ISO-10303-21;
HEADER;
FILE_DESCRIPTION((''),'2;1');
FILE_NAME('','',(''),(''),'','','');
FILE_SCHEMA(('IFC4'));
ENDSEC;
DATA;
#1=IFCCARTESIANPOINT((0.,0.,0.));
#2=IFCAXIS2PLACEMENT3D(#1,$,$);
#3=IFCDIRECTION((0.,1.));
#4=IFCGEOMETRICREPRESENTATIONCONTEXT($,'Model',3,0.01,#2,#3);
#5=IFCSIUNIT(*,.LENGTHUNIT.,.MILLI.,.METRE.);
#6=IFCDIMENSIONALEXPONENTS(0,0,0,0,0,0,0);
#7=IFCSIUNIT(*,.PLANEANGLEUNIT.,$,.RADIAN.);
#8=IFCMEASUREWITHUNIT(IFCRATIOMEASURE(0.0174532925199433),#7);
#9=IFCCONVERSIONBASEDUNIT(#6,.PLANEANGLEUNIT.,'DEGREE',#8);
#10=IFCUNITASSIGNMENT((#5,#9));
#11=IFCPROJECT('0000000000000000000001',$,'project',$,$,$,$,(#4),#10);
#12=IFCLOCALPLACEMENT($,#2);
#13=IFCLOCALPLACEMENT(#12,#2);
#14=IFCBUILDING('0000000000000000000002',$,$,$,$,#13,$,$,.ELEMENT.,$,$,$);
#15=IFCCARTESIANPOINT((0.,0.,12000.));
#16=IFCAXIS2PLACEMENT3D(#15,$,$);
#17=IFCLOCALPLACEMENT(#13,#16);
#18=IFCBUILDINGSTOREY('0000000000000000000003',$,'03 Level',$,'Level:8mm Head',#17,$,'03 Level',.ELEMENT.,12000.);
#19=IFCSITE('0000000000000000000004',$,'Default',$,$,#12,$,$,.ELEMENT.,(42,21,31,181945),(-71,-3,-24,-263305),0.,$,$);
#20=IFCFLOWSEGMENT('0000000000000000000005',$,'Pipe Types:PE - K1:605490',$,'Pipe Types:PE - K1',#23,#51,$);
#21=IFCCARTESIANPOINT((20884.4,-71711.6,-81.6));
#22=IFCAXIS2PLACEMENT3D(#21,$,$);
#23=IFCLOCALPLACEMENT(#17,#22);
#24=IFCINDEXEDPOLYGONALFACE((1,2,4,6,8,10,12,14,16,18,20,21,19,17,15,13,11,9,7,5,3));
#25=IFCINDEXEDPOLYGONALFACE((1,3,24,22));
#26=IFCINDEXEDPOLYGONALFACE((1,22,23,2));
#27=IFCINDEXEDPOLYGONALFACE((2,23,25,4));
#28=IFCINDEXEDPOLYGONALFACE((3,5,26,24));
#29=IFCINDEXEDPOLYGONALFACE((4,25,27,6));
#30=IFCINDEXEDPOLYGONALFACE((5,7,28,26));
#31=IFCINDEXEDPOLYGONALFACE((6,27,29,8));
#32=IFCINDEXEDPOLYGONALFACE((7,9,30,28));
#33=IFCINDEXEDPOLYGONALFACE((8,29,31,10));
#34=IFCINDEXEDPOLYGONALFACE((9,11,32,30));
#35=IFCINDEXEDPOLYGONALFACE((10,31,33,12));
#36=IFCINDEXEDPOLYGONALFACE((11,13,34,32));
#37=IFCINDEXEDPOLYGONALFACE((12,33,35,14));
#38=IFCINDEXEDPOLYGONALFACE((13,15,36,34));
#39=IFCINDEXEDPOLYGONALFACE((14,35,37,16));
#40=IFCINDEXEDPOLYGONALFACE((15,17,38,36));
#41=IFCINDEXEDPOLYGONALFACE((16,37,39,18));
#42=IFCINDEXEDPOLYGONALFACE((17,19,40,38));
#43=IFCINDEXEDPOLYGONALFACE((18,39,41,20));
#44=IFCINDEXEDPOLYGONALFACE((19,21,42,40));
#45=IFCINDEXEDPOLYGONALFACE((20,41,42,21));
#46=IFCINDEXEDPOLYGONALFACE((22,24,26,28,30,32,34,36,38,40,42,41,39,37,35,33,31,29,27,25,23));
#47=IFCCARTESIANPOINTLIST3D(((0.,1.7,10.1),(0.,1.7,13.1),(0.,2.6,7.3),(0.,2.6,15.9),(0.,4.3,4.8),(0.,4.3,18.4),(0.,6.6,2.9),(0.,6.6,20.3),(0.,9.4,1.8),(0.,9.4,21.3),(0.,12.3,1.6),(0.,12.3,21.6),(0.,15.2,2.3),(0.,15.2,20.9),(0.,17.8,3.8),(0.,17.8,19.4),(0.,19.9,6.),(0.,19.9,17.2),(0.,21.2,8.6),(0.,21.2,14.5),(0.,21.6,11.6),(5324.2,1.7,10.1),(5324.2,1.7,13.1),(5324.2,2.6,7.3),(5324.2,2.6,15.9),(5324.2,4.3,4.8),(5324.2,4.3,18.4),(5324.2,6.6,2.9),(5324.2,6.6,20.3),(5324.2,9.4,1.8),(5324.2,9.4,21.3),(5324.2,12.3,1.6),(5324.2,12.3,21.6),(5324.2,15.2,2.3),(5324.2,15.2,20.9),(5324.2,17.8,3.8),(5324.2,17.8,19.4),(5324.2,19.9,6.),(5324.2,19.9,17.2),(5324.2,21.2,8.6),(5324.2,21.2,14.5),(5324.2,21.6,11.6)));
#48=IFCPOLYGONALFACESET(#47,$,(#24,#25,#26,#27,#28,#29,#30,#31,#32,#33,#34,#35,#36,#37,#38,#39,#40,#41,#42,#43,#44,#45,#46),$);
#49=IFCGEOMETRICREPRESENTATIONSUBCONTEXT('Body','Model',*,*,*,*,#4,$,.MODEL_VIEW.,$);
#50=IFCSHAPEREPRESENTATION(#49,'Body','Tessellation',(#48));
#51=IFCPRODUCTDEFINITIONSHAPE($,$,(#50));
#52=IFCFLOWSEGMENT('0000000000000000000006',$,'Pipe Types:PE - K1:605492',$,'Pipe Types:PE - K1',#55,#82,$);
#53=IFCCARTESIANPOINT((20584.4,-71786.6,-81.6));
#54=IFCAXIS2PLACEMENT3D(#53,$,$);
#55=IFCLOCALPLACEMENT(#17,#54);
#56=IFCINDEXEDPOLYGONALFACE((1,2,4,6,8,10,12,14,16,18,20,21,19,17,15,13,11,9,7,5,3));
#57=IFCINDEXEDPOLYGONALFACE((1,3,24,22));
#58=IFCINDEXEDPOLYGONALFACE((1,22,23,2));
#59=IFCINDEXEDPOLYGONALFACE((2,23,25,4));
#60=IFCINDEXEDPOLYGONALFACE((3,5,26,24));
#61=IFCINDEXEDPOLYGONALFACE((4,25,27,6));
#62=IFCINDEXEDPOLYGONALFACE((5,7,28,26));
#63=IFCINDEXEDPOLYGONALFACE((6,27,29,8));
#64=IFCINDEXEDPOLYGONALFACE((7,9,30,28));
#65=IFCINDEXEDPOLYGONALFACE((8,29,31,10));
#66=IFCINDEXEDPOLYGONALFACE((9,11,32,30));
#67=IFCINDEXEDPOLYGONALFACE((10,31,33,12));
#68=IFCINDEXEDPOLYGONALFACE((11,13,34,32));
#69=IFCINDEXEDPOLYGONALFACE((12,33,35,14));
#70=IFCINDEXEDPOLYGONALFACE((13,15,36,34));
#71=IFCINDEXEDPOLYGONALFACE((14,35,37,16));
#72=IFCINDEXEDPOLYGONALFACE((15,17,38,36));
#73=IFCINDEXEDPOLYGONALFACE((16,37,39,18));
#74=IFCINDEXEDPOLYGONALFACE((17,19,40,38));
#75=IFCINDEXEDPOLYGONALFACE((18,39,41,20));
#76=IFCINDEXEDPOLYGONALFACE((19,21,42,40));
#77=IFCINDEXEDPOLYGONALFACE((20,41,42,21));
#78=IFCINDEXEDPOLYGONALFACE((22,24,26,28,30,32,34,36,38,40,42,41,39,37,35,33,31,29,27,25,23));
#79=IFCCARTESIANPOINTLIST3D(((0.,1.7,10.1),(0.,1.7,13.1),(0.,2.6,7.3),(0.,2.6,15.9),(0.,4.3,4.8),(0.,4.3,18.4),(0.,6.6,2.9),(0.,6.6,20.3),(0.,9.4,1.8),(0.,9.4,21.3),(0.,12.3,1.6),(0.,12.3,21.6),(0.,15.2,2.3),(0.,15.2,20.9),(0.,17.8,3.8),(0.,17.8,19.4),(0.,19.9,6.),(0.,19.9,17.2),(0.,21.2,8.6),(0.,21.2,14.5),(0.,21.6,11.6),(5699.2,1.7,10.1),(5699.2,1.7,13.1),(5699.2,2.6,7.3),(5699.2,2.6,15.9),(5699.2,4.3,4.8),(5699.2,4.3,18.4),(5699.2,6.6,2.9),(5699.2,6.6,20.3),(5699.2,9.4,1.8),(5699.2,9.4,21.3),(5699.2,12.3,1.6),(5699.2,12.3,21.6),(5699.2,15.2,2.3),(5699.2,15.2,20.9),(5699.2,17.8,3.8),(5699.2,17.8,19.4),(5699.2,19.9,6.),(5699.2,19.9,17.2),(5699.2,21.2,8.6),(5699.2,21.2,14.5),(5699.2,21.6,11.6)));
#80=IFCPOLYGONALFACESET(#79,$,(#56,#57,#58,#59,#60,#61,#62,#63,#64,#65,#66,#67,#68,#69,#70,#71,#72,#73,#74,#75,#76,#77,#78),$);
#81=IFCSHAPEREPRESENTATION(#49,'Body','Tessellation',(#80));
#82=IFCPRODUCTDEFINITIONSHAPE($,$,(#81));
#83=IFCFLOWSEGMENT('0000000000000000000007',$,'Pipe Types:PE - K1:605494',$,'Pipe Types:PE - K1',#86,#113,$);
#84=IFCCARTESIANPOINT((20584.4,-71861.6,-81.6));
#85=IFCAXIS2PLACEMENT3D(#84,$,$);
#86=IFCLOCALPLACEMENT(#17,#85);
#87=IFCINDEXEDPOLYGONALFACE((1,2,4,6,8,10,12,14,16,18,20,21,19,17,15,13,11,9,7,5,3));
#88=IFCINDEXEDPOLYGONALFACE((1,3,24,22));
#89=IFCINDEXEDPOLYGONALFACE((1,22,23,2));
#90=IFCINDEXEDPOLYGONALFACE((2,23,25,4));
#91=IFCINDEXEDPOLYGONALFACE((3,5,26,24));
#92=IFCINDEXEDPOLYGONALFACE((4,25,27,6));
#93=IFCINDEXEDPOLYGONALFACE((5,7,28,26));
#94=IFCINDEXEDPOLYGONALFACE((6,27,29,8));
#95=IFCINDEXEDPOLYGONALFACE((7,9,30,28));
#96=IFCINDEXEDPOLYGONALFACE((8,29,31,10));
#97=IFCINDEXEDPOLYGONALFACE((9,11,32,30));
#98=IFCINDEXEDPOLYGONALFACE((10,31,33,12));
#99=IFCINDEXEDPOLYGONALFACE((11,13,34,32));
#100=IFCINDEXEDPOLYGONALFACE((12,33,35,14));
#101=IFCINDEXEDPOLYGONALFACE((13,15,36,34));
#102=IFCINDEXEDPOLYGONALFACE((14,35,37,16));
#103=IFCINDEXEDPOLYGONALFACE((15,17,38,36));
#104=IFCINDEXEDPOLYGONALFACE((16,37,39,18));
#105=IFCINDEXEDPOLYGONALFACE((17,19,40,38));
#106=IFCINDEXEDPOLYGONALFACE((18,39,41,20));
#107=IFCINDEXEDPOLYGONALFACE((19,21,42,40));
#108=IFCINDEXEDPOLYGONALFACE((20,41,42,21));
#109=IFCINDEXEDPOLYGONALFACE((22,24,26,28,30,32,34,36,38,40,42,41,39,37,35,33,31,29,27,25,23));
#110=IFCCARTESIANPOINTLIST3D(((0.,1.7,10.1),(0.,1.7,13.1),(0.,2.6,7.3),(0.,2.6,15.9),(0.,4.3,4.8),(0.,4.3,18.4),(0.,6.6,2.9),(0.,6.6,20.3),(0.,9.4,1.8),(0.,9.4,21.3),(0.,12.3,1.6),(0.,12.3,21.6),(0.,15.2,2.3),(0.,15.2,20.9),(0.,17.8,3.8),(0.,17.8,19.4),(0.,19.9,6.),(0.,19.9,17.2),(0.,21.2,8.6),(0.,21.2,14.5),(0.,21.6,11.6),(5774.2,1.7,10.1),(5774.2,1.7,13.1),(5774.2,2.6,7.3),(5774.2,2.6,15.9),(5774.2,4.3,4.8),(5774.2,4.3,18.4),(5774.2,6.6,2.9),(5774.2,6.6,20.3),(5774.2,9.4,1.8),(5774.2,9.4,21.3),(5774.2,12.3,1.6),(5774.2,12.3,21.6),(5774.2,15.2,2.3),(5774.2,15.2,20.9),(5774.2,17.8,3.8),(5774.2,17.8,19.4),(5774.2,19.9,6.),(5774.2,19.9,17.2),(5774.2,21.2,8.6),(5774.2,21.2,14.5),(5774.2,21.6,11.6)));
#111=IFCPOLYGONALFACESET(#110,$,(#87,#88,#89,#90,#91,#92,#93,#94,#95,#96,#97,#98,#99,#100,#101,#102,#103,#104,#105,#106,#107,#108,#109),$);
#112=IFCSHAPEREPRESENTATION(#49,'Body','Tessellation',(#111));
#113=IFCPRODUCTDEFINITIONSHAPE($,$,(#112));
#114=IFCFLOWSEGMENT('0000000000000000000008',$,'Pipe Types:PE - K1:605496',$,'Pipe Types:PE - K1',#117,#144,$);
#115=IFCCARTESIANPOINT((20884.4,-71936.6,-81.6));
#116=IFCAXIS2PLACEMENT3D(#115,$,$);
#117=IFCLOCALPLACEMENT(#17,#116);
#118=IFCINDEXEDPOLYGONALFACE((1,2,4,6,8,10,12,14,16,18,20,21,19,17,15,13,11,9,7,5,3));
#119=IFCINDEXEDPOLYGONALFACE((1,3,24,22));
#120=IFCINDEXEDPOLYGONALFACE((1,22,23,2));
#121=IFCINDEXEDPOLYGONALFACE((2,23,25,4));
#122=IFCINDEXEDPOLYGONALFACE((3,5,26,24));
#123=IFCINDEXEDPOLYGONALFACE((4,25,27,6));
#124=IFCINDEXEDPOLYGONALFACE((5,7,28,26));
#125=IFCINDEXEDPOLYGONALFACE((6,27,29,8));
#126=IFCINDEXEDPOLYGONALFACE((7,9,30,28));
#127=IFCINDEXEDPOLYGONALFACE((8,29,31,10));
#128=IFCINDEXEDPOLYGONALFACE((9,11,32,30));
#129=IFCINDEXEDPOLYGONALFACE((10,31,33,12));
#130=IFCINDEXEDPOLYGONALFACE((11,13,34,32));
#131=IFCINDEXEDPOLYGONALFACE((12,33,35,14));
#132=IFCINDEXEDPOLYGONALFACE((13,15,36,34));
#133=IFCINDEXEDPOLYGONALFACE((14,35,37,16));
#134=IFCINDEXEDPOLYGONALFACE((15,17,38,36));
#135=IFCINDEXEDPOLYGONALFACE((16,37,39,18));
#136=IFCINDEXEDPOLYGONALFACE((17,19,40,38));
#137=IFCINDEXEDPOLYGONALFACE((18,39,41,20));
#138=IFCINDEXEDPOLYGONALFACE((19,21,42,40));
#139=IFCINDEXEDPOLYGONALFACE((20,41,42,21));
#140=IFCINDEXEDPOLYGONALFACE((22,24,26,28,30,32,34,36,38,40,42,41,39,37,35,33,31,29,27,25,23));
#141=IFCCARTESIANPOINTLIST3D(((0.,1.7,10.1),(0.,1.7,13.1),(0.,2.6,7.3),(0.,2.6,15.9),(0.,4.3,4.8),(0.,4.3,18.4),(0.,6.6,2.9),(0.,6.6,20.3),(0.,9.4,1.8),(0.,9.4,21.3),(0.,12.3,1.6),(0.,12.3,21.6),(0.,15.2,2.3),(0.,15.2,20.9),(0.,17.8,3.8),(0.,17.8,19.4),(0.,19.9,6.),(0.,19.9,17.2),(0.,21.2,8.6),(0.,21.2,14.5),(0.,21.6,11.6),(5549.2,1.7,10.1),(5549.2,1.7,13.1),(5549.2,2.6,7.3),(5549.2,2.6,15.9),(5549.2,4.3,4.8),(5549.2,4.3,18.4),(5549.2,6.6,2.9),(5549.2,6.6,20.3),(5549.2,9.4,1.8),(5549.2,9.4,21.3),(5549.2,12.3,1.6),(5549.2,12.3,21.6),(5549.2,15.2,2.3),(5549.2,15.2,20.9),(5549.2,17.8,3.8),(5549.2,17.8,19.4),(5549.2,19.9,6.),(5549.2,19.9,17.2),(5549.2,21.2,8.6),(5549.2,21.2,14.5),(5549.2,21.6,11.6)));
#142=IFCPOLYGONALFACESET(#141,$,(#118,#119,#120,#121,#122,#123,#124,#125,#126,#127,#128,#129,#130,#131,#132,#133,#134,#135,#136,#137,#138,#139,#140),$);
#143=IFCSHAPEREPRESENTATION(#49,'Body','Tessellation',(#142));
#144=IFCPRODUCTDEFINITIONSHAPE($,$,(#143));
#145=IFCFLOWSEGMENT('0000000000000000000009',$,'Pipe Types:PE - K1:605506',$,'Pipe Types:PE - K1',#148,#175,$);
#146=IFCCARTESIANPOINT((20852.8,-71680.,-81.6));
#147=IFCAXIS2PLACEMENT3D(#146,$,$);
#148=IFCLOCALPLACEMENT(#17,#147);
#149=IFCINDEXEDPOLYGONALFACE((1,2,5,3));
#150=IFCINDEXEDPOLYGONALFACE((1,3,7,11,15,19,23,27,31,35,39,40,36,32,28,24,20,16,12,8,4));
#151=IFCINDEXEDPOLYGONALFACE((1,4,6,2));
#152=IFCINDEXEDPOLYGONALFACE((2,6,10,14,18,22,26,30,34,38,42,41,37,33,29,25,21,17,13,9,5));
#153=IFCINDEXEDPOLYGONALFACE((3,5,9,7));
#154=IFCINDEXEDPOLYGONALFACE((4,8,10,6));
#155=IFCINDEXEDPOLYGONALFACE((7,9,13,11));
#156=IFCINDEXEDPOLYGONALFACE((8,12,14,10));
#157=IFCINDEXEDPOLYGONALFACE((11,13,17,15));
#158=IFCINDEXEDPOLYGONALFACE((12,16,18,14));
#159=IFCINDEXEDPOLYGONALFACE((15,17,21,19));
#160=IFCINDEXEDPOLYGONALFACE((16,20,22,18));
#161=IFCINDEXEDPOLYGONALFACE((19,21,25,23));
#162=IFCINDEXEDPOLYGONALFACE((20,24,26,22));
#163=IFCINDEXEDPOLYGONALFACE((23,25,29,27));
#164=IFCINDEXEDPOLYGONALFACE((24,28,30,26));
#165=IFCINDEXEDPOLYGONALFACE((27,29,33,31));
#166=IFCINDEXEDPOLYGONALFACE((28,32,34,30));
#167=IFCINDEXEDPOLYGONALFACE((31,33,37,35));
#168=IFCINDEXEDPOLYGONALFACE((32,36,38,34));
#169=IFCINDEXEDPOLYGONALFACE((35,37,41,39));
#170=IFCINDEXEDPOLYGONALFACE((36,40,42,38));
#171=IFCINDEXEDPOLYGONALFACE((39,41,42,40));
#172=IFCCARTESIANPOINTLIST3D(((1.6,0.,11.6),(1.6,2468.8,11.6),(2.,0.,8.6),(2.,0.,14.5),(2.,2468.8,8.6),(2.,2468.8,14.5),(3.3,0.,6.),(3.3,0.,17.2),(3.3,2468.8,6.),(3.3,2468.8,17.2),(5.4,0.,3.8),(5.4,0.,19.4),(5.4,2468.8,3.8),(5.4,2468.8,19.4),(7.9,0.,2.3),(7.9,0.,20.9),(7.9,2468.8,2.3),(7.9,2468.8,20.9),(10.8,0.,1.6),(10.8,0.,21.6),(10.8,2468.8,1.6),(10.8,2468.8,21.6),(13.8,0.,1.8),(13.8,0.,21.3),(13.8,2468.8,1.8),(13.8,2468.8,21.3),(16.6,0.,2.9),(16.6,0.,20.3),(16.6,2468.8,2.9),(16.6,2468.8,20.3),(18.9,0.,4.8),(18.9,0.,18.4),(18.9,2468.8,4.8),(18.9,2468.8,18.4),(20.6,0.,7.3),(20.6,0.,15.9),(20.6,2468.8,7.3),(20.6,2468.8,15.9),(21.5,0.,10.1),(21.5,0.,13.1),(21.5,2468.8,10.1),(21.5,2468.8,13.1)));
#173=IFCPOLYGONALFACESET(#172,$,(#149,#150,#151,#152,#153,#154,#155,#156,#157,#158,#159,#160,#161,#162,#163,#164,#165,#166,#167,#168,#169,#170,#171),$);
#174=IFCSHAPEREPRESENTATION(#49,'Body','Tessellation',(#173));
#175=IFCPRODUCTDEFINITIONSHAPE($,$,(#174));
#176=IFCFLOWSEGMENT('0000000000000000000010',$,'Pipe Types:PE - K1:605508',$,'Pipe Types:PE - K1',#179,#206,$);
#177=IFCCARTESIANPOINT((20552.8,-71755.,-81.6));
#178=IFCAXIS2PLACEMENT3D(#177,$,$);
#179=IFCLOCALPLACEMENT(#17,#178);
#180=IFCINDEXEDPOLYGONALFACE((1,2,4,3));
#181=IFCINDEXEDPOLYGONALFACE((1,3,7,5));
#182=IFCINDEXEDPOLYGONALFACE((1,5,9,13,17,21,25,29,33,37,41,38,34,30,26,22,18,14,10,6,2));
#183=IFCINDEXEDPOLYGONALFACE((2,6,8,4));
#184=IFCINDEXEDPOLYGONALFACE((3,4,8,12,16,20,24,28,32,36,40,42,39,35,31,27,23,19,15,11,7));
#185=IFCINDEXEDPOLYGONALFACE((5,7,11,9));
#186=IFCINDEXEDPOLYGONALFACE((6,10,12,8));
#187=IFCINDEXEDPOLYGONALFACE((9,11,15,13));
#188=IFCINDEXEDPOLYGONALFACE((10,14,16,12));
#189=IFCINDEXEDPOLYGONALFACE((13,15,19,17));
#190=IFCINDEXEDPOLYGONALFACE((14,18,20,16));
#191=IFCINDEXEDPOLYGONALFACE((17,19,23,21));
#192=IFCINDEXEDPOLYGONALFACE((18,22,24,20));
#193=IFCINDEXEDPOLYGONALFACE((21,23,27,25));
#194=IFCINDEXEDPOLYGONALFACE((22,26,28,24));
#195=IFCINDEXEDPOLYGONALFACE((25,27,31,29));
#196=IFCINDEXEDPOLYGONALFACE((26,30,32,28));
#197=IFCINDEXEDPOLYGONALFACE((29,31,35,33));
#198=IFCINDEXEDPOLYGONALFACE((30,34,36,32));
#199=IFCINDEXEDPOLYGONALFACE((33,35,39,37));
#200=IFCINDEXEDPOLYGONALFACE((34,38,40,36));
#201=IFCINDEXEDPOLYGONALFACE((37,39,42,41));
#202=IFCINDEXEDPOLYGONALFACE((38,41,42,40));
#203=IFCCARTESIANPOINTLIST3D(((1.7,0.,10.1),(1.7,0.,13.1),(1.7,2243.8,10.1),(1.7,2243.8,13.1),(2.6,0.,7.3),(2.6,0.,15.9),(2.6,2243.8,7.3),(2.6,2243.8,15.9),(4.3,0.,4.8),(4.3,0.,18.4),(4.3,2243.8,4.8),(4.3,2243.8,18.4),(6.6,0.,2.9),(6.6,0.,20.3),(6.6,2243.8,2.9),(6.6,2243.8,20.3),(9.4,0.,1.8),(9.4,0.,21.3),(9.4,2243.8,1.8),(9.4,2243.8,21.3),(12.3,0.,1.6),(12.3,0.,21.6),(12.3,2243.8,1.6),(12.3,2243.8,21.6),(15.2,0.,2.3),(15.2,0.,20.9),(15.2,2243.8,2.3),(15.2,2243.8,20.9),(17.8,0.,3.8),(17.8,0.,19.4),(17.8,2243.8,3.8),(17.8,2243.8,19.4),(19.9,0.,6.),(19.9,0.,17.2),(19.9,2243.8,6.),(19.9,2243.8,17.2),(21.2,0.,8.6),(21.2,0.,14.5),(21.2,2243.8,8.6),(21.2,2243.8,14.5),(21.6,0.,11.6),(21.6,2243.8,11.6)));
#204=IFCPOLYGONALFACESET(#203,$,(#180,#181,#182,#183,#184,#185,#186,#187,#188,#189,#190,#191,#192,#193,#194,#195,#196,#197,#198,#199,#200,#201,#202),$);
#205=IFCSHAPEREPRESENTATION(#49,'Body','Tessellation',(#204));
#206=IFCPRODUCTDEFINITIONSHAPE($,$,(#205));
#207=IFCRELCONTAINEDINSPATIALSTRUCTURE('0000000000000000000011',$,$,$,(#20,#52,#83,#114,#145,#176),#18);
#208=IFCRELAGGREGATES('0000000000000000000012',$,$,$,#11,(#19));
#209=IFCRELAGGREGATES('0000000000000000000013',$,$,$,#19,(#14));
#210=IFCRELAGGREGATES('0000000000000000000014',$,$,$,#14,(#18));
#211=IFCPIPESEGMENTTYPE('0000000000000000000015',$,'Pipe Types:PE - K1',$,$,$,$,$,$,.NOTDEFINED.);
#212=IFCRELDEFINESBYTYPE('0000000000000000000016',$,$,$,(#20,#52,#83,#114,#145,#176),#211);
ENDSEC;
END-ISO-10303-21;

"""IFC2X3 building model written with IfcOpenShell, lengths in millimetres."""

from ifc_helpers import new_model, entity, si_unit, converted_unit, direction, frame, frame_2d, origin, origin_2d_with_axis, place, context, subcontext, project, spatial, circle, extrude, type_object, element, save


model = new_model("IFC2X3")

# Units and contexts
model_context = context("Model", 3, precision=0.01, world=origin(), true_north=direction((0.0, 1.0)))
body_context = subcontext(model_context, "Body", "Model", "MODEL_VIEW")
ifc_project = project(units=[si_unit("LENGTHUNIT", "METRE", prefix="MILLI"), converted_unit("PLANEANGLEUNIT", "DEGREE", entity("IfcRatioMeasure", 0.0174532925199433), si_unit("PLANEANGLEUNIT", "RADIAN"), dimensions=[0, 0, 0, 0, 0, 0, 0])], contexts=[model_context])

# Site, building, storey
site_placement = place(None, origin())
site = spatial("IfcSite", under=ifc_project, at=site_placement, Name="Default", CompositionType="ELEMENT", RefLatitude=(42, 21, 31, 181945), RefLongitude=(-71, -3, -24, -263305), RefElevation=0.0)
building_placement = place(site_placement, origin())
building = spatial("IfcBuilding", under=site, at=building_placement, CompositionType="ELEMENT")
storey_placement = place(building_placement, frame((0.0, 0.0, 12000.0)))
storey = spatial("IfcBuildingStorey", under=building, at=storey_placement, Name="03 Level", ObjectType="Level:8mm Head", LongName="03 Level", CompositionType="ELEMENT", Elevation=12000.0)

# Flow segments
pipe_segment_type = type_object("IfcPipeSegmentType", Name="Pipe Types:PE - K1", PredefinedType="NOTDEFINED")
flow_segment_1_placement = place(storey_placement, frame((20884.4, -71711.6, -81.6)))
element("IfcFlowSegment", 1, at=flow_segment_1_placement, inside=storey, type_object=pipe_segment_type, Name="Pipe Types:PE - K1:605490", ObjectType="Pipe Types:PE - K1", context=body_context, shape_type="SweptSolid", body=[
    extrude(circle(Radius=10.0, at=frame_2d((0.0, 0.0), x_axis=(1.0, 0.0))), frame((0.0, 11.6, 11.6), z_axis=(1.0, 0.0, 0.0), x_axis=(0.0, 1.0, 0.0)), (0.0, 0.0, 1.0), 5324.2),
])
flow_segment_2_placement = place(storey_placement, frame((20584.4, -71786.6, -81.6)))
element("IfcFlowSegment", 2, at=flow_segment_2_placement, inside=storey, type_object=pipe_segment_type, Name="Pipe Types:PE - K1:605492", ObjectType="Pipe Types:PE - K1", context=body_context, shape_type="SweptSolid", body=[
    extrude(circle(Radius=10.0, at=frame_2d((0.0, 0.0), x_axis=(1.0, 0.0))), frame((0.0, 11.6, 11.6), z_axis=(1.0, 0.0, 0.0), x_axis=(0.0, 1.0, 0.0)), (0.0, 0.0, 1.0), 5699.2),
])
flow_segment_3_placement = place(storey_placement, frame((20584.4, -71861.6, -81.6)))
element("IfcFlowSegment", 3, at=flow_segment_3_placement, inside=storey, type_object=pipe_segment_type, Name="Pipe Types:PE - K1:605494", ObjectType="Pipe Types:PE - K1", context=body_context, shape_type="SweptSolid", body=[
    extrude(circle(Radius=10.0, at=frame_2d((0.0, 0.0), x_axis=(1.0, 0.0))), frame((0.0, 11.6, 11.6), z_axis=(1.0, 0.0, 0.0), x_axis=(0.0, 1.0, 0.0)), (0.0, 0.0, 1.0), 5774.2),
])
flow_segment_4_placement = place(storey_placement, frame((20884.4, -71936.6, -81.6)))
element("IfcFlowSegment", 4, at=flow_segment_4_placement, inside=storey, type_object=pipe_segment_type, Name="Pipe Types:PE - K1:605496", ObjectType="Pipe Types:PE - K1", context=body_context, shape_type="SweptSolid", body=[
    extrude(circle(Radius=10.0, at=frame_2d((0.0, 0.0), x_axis=(1.0, 0.0))), frame((0.0, 11.6, 11.6), z_axis=(1.0, 0.0, 0.0), x_axis=(0.0, 1.0, 0.0)), (0.0, 0.0, 1.0), 5549.2),
])
flow_segment_5_placement = place(storey_placement, frame((20852.8, -71680.0, -81.6)))
element("IfcFlowSegment", 5, at=flow_segment_5_placement, inside=storey, type_object=pipe_segment_type, Name="Pipe Types:PE - K1:605506", ObjectType="Pipe Types:PE - K1", context=body_context, shape_type="SweptSolid", body=[
    extrude(circle(Radius=10.0, at=frame_2d((0.0, 0.0), x_axis=(1.0, 0.0))), frame((11.6, 0.0, 11.6), z_axis=(0.0, 1.0, 0.0), x_axis=(-1.0, 0.0, 0.0)), (0.0, 0.0, 1.0), 2468.8),
])
flow_segment_6_placement = place(storey_placement, frame((20552.8, -71755.0, -81.6)))
element("IfcFlowSegment", 6, at=flow_segment_6_placement, inside=storey, type_object=pipe_segment_type, Name="Pipe Types:PE - K1:605508", ObjectType="Pipe Types:PE - K1", context=body_context, shape_type="SweptSolid", body=[
    extrude(circle(Radius=10.0, at=origin_2d_with_axis()), frame((11.6, 0.0, 11.6), z_axis=(0.0, 1.0, 0.0), x_axis=(1.0, 0.0, 0.0)), (0.0, 0.0, 1.0), 2243.8),
])

save(model, "model.ifc")
